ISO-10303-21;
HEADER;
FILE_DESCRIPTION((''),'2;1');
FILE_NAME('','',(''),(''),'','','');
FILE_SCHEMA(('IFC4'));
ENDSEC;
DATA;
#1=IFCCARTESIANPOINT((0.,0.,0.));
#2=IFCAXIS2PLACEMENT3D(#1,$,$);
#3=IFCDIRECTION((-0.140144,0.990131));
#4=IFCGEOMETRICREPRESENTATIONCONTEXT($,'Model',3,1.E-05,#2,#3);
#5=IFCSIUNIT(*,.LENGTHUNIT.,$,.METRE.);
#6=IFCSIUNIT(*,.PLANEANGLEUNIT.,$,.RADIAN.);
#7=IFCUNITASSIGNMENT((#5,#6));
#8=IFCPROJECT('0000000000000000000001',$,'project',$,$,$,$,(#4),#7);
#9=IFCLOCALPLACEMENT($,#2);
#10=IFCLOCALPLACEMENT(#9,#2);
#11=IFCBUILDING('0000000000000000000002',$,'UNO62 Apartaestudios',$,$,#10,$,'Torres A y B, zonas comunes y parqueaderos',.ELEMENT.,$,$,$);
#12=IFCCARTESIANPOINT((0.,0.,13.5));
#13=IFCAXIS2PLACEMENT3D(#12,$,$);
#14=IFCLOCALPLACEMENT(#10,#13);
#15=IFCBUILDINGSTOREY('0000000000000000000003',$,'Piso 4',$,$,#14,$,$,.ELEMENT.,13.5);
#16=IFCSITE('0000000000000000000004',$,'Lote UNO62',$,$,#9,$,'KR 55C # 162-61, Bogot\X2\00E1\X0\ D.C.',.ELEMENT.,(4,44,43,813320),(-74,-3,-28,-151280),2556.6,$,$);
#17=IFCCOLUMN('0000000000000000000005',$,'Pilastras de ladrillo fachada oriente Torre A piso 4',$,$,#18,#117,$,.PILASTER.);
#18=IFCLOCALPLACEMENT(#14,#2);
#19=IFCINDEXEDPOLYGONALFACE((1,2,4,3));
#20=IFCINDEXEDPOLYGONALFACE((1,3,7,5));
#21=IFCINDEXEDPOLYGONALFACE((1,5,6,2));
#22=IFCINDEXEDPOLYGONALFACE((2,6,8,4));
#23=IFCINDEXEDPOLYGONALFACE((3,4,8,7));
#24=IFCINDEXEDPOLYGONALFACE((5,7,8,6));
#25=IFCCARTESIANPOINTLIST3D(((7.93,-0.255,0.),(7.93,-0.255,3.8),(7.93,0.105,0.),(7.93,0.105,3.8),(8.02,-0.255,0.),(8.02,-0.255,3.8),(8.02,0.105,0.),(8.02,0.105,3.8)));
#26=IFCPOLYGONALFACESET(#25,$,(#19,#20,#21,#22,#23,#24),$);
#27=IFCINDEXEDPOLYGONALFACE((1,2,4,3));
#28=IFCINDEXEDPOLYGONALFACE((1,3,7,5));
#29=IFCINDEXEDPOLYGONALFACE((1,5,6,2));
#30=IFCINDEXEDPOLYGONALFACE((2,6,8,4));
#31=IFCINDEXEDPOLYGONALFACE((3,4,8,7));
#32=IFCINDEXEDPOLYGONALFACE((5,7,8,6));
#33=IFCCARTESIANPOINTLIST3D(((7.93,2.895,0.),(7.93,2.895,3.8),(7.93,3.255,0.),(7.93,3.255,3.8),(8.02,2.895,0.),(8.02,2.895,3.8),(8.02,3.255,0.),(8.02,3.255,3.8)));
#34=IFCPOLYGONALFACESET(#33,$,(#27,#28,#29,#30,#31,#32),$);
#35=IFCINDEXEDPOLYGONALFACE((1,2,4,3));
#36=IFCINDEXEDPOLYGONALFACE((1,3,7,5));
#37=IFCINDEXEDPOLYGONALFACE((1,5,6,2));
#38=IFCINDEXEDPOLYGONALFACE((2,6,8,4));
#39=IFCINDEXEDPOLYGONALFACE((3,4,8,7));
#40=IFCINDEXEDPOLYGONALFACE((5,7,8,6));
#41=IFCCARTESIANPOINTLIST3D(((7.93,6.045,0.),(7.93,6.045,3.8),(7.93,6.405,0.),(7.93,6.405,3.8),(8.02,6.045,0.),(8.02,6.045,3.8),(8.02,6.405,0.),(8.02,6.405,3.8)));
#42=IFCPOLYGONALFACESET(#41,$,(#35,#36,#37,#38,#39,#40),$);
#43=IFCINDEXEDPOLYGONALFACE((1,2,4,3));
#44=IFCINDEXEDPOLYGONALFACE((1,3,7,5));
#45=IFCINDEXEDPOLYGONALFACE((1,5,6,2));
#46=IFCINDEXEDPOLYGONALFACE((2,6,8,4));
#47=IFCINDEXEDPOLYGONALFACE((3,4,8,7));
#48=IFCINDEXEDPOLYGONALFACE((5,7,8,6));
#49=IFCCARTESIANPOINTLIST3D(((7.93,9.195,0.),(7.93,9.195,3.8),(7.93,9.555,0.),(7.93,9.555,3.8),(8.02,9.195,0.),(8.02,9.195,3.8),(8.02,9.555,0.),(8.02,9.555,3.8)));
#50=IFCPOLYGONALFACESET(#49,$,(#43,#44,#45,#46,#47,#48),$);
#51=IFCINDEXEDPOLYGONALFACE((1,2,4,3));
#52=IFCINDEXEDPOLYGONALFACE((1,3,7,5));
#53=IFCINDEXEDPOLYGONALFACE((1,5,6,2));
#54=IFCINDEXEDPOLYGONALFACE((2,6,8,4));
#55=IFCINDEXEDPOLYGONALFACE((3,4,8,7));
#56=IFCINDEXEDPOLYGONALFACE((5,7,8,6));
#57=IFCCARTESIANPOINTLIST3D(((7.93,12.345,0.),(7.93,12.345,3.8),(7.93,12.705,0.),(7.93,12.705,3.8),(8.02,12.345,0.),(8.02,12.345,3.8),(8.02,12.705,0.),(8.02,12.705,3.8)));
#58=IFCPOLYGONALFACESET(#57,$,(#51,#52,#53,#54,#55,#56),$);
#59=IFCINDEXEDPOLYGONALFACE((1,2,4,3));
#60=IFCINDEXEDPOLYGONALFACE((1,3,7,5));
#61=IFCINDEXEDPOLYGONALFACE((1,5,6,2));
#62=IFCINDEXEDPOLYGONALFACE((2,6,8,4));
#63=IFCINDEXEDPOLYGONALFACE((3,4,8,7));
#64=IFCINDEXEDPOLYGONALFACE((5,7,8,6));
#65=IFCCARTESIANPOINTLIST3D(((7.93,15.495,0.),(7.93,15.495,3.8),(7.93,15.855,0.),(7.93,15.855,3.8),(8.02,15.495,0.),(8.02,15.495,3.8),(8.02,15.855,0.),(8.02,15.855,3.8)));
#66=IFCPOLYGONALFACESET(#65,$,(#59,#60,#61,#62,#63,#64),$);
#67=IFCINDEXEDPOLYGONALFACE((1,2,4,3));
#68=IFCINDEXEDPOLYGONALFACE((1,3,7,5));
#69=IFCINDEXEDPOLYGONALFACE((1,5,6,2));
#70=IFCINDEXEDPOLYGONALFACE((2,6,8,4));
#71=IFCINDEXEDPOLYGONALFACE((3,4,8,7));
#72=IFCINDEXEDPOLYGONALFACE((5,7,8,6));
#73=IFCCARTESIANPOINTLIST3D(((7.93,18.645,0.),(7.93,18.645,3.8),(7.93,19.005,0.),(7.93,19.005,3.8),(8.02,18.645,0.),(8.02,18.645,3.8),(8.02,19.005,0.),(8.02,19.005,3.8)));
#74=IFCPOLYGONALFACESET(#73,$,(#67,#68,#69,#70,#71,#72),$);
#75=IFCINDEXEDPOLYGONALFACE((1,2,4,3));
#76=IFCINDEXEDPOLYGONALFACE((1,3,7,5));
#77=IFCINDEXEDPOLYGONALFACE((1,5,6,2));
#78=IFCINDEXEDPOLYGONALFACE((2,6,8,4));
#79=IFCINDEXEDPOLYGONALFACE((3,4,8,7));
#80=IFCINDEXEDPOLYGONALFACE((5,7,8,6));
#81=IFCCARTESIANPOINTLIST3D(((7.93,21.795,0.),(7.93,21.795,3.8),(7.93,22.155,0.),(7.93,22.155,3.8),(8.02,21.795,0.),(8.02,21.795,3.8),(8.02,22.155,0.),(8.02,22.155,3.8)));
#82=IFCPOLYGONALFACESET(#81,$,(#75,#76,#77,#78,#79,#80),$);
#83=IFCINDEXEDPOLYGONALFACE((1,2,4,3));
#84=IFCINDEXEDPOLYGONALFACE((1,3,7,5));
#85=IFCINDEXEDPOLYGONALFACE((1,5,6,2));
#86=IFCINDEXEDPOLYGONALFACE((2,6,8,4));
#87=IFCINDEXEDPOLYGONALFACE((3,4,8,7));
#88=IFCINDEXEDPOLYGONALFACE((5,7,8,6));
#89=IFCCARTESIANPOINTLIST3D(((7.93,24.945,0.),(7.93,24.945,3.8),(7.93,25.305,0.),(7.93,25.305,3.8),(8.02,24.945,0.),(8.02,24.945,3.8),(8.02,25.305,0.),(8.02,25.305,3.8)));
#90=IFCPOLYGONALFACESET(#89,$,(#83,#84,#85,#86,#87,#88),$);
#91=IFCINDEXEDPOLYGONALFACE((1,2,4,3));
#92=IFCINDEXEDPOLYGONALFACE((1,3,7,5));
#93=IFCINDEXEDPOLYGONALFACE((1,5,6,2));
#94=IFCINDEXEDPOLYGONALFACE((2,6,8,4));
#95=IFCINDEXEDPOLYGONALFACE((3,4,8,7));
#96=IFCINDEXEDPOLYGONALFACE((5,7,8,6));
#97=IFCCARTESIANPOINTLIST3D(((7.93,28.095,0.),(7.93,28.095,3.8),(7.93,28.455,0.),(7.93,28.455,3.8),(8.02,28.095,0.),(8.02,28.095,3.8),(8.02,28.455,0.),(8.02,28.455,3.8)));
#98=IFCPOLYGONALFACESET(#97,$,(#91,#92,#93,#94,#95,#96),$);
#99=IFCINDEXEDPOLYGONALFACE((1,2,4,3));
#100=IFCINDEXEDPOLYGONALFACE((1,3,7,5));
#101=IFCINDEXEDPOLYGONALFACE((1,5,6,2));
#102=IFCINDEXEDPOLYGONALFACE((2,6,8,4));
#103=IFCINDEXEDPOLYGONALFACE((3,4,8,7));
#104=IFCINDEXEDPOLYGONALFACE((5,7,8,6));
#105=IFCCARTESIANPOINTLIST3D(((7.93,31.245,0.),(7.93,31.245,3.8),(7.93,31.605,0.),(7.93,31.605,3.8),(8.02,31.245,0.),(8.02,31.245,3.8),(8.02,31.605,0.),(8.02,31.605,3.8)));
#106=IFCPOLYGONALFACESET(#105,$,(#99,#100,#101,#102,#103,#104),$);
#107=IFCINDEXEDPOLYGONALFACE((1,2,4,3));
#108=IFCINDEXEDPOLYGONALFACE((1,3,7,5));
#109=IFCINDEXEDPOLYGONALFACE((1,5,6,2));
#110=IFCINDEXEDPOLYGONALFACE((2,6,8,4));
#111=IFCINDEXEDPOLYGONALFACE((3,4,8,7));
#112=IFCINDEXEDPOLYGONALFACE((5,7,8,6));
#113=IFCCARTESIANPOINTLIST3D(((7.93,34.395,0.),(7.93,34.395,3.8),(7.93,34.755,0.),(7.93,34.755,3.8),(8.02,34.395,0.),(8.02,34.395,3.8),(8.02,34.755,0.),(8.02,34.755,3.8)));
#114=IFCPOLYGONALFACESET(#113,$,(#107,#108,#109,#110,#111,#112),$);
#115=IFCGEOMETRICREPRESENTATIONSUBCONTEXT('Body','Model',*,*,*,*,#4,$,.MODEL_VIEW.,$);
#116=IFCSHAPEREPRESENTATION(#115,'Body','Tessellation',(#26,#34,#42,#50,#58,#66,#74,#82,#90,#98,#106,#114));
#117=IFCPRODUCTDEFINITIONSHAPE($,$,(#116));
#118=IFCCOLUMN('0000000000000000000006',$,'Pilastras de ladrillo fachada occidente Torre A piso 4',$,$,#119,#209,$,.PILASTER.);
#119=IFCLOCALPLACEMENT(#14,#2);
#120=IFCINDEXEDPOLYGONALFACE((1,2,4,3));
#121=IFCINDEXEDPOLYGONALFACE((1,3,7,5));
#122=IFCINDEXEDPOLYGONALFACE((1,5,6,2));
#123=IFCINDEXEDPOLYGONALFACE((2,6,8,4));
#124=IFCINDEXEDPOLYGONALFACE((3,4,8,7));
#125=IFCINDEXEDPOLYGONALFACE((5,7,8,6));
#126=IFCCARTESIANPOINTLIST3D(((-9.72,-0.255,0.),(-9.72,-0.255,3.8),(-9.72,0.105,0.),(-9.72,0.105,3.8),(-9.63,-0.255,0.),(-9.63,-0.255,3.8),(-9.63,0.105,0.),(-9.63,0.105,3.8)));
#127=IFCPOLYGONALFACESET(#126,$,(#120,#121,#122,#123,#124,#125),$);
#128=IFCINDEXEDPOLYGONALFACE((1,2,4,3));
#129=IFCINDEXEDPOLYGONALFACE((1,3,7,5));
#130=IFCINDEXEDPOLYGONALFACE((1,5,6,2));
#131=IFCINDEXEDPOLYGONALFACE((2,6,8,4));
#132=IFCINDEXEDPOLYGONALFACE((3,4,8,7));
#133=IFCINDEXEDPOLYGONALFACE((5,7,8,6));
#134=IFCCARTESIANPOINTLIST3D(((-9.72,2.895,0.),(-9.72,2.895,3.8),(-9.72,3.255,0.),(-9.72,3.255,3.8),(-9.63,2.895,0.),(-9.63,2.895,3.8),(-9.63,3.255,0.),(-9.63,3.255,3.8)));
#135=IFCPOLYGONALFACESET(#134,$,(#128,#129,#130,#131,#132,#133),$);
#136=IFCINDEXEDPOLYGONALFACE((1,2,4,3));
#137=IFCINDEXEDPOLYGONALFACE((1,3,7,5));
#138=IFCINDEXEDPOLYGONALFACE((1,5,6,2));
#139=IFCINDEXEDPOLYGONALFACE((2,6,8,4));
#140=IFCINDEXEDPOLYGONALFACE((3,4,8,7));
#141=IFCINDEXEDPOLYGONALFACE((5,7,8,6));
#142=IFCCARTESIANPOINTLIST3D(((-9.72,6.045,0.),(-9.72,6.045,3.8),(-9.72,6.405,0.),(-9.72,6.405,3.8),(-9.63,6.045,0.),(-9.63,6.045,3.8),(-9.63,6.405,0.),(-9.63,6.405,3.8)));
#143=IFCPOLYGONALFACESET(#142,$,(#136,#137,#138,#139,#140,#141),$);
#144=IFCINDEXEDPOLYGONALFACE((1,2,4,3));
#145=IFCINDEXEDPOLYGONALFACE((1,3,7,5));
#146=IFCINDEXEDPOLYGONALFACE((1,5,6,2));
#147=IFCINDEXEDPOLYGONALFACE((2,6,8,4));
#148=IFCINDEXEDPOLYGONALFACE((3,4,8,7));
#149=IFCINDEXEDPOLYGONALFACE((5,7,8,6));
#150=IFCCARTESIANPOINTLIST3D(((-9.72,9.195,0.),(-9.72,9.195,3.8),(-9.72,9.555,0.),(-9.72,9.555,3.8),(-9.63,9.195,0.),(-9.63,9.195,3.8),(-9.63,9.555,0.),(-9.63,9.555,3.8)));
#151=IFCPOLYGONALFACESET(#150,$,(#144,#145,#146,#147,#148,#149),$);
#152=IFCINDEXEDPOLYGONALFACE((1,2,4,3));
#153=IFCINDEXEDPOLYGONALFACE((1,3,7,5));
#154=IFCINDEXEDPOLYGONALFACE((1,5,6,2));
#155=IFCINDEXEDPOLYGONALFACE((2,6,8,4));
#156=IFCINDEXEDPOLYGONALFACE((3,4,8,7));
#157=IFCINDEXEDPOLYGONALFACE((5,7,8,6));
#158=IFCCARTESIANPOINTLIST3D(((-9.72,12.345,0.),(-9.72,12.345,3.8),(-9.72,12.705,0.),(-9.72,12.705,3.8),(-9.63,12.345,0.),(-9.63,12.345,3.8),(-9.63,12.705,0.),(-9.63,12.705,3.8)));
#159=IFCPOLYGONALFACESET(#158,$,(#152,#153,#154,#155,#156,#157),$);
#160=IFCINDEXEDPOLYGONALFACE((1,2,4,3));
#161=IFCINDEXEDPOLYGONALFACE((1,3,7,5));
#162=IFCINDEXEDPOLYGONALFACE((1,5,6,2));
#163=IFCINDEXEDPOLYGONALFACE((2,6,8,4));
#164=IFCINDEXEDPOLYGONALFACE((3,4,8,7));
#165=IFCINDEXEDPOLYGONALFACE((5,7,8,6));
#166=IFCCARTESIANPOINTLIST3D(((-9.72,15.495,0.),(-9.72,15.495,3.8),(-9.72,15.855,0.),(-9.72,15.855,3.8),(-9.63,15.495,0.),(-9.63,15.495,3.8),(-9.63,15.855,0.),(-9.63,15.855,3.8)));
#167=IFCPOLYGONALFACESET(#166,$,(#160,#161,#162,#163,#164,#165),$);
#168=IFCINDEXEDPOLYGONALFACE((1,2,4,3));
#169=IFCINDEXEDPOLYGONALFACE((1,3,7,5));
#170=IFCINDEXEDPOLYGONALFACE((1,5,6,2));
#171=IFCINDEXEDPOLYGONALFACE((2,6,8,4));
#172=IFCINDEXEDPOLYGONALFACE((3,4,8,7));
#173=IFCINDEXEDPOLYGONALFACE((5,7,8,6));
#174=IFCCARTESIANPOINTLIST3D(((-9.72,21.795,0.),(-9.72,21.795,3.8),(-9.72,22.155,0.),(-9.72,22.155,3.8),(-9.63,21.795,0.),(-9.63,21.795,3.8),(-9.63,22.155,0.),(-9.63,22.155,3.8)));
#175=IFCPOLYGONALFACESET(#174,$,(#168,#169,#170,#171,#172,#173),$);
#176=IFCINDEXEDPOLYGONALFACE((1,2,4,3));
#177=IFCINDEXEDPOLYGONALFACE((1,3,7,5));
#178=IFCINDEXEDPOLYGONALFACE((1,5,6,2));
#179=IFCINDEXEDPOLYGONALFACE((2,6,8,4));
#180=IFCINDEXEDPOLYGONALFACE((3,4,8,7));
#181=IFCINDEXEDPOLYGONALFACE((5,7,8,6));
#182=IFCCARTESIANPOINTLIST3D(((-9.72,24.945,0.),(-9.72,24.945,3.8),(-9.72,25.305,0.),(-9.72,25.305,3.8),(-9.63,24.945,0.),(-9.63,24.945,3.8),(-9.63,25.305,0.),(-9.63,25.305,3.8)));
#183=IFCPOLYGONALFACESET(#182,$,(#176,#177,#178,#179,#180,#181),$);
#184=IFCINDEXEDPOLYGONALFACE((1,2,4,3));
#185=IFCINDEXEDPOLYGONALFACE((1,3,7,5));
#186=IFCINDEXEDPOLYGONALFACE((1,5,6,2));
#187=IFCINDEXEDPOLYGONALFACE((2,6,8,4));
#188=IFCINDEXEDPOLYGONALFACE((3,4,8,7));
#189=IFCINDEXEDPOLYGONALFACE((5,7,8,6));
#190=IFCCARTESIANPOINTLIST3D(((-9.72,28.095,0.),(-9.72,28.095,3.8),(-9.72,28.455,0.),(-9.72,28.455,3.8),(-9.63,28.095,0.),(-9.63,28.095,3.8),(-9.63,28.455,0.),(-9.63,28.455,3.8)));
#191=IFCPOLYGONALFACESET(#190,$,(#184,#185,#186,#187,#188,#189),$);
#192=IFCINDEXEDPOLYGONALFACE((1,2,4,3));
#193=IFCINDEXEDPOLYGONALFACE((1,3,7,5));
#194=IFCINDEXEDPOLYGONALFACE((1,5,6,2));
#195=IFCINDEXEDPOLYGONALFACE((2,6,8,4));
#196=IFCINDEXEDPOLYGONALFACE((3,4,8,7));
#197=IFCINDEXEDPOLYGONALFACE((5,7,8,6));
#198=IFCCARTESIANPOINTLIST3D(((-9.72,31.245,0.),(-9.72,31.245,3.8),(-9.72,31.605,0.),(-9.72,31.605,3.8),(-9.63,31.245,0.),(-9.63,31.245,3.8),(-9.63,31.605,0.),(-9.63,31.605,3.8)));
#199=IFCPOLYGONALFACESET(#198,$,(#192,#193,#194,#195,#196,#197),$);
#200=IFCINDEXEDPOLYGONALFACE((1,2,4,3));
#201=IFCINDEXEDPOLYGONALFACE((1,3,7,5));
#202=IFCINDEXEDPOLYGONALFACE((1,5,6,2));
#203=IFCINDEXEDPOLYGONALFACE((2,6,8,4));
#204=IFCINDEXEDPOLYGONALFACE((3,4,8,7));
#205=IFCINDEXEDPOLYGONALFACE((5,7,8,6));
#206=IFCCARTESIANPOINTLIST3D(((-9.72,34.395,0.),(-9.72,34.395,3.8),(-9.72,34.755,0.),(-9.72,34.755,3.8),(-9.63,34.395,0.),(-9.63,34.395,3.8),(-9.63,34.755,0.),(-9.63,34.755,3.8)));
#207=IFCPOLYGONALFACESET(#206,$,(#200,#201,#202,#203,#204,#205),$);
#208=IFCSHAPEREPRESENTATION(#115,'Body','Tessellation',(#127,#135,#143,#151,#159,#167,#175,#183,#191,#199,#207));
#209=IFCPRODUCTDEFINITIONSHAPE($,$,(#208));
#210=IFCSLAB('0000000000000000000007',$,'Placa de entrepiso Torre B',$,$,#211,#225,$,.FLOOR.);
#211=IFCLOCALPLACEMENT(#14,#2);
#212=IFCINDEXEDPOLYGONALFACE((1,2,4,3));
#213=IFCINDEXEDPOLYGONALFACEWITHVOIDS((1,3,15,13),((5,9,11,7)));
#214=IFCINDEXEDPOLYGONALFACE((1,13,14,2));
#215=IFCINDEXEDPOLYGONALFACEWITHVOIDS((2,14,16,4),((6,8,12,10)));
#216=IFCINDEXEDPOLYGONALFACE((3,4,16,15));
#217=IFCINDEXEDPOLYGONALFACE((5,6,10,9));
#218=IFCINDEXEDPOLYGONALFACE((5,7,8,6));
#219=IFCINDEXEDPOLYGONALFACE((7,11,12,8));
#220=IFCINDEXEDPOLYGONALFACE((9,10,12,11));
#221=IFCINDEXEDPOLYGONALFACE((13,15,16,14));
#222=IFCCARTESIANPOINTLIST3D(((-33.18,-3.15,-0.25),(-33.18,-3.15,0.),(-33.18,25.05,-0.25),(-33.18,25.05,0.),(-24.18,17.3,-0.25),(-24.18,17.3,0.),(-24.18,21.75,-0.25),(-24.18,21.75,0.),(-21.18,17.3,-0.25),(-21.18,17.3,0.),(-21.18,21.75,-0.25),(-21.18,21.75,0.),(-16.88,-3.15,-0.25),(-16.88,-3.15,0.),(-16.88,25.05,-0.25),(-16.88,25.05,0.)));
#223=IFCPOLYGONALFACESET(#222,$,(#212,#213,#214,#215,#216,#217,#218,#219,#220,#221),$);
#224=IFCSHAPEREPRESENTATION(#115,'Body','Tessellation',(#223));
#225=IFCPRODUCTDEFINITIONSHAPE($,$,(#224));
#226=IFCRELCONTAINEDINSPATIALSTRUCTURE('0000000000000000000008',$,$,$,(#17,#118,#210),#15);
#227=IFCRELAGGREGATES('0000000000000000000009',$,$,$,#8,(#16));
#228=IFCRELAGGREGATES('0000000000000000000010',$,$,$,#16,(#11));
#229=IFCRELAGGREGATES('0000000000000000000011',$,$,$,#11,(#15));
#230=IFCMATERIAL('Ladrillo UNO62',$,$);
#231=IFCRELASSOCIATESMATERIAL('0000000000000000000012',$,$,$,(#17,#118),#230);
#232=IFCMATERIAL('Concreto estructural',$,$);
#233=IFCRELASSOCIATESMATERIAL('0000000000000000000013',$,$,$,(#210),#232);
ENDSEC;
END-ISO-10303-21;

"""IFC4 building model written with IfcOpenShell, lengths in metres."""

from ifc_helpers import new_model, si_unit, direction, frame, frame_2d, origin, place, context, subcontext, project, spatial, rectangle, extrude, material, element, save


model = new_model("IFC4")

# Units and contexts
model_context = context("Model", 3, precision=1e-05, world=origin(), true_north=direction((-0.140144, 0.990131)))
body_context = subcontext(model_context, "Body", "Model", "MODEL_VIEW")
ifc_project = project(units=[si_unit("LENGTHUNIT", "METRE"), si_unit("PLANEANGLEUNIT", "RADIAN")], contexts=[model_context])

# Site, building, storey
site_placement = place(None, origin())
site = spatial("IfcSite", under=ifc_project, at=site_placement, Name="Lote UNO62", LongName="KR 55C # 162-61, Bogotá D.C.", CompositionType="ELEMENT", RefLatitude=(4, 44, 43, 813320), RefLongitude=(-74, -3, -28, -151280), RefElevation=2556.6)
building_placement = place(site_placement, origin())
building = spatial("IfcBuilding", under=site, at=building_placement, Name="UNO62 Apartaestudios", LongName="Torres A y B, zonas comunes y parqueaderos", CompositionType="ELEMENT")
storey_placement = place(building_placement, frame((0.0, 0.0, 13.5)))
storey = spatial("IfcBuildingStorey", under=building, at=storey_placement, Name="Piso 4", CompositionType="ELEMENT", Elevation=13.5)

# Columns
ifc_material_1 = material(Name="Ladrillo UNO62")
column_1_placement = place(storey_placement, origin())
element("IfcColumn", 1, at=column_1_placement, inside=storey, material=ifc_material_1, Name="Pilastras de ladrillo fachada oriente Torre A piso 4", PredefinedType="PILASTER", context=body_context, shape_type="SweptSolid", body=[
    extrude(rectangle(XDim=0.09, YDim=0.36, at=frame_2d((7.975, -0.075))), origin(), (0.0, 0.0, 1.0), 3.8),
    extrude(rectangle(XDim=0.09, YDim=0.36, at=frame_2d((7.975, 3.075))), origin(), (0.0, 0.0, 1.0), 3.8),
    extrude(rectangle(XDim=0.09, YDim=0.36, at=frame_2d((7.975, 6.225))), origin(), (0.0, 0.0, 1.0), 3.8),
    extrude(rectangle(XDim=0.09, YDim=0.36, at=frame_2d((7.975, 9.375))), origin(), (0.0, 0.0, 1.0), 3.8),
    extrude(rectangle(XDim=0.09, YDim=0.36, at=frame_2d((7.975, 12.525))), origin(), (0.0, 0.0, 1.0), 3.8),
    extrude(rectangle(XDim=0.09, YDim=0.36, at=frame_2d((7.975, 15.675))), origin(), (0.0, 0.0, 1.0), 3.8),
    extrude(rectangle(XDim=0.09, YDim=0.36, at=frame_2d((7.975, 18.825))), origin(), (0.0, 0.0, 1.0), 3.8),
    extrude(rectangle(XDim=0.09, YDim=0.36, at=frame_2d((7.975, 21.975))), origin(), (0.0, 0.0, 1.0), 3.8),
    extrude(rectangle(XDim=0.09, YDim=0.36, at=frame_2d((7.975, 25.125))), origin(), (0.0, 0.0, 1.0), 3.8),
    extrude(rectangle(XDim=0.09, YDim=0.36, at=frame_2d((7.975, 28.275))), origin(), (0.0, 0.0, 1.0), 3.8),
    extrude(rectangle(XDim=0.09, YDim=0.36, at=frame_2d((7.975, 31.425))), origin(), (0.0, 0.0, 1.0), 3.8),
    extrude(rectangle(XDim=0.09, YDim=0.36, at=frame_2d((7.975, 34.575))), origin(), (0.0, 0.0, 1.0), 3.8),
])
column_2_placement = place(storey_placement, origin())
element("IfcColumn", 2, at=column_2_placement, inside=storey, material=ifc_material_1, Name="Pilastras de ladrillo fachada occidente Torre A piso 4", PredefinedType="PILASTER", context=body_context, shape_type="SweptSolid", body=[
    extrude(rectangle(XDim=0.09, YDim=0.36, at=frame_2d((-9.675, -0.075))), origin(), (0.0, 0.0, 1.0), 3.8),
    extrude(rectangle(XDim=0.09, YDim=0.36, at=frame_2d((-9.675, 3.075))), origin(), (0.0, 0.0, 1.0), 3.8),
    extrude(rectangle(XDim=0.09, YDim=0.36, at=frame_2d((-9.675, 6.225))), origin(), (0.0, 0.0, 1.0), 3.8),
    extrude(rectangle(XDim=0.09, YDim=0.36, at=frame_2d((-9.675, 9.375))), origin(), (0.0, 0.0, 1.0), 3.8),
    extrude(rectangle(XDim=0.09, YDim=0.36, at=frame_2d((-9.675, 12.525))), origin(), (0.0, 0.0, 1.0), 3.8),
    extrude(rectangle(XDim=0.09, YDim=0.36, at=frame_2d((-9.675, 15.675))), origin(), (0.0, 0.0, 1.0), 3.8),
    extrude(rectangle(XDim=0.09, YDim=0.36, at=frame_2d((-9.675, 21.975))), origin(), (0.0, 0.0, 1.0), 3.8),
    extrude(rectangle(XDim=0.09, YDim=0.36, at=frame_2d((-9.675, 25.125))), origin(), (0.0, 0.0, 1.0), 3.8),
    extrude(rectangle(XDim=0.09, YDim=0.36, at=frame_2d((-9.675, 28.275))), origin(), (0.0, 0.0, 1.0), 3.8),
    extrude(rectangle(XDim=0.09, YDim=0.36, at=frame_2d((-9.675, 31.425))), origin(), (0.0, 0.0, 1.0), 3.8),
    extrude(rectangle(XDim=0.09, YDim=0.36, at=frame_2d((-9.675, 34.575))), origin(), (0.0, 0.0, 1.0), 3.8),
])

# Slab, opening
ifc_material_2 = material(Name="Concreto estructural")
slab_placement = place(storey_placement, origin())
slab = element("IfcSlab", 3, at=slab_placement, inside=storey, material=ifc_material_2, Name="Placa de entrepiso Torre B", PredefinedType="FLOOR", context=body_context, shape_type="SweptSolid", body=[
    extrude(rectangle(XDim=16.3, YDim=28.2, at=frame_2d((-25.03, 10.95))), frame((0.0, 0.0, -0.25)), (0.0, 0.0, 1.0), 0.25),
])
opening_1_placement = place(slab_placement, origin())
element("IfcOpeningElement", 4, at=opening_1_placement, cuts=slab, PredefinedType="OPENING", context=body_context, shape_type="SweptSolid", body=[
    extrude(rectangle(XDim=3.0, YDim=4.45, at=frame_2d((-22.68, 19.525))), frame((0.0, 0.0, -0.3)), (0.0, 0.0, 1.0), 0.35),
])

save(model, "model.ifc")
